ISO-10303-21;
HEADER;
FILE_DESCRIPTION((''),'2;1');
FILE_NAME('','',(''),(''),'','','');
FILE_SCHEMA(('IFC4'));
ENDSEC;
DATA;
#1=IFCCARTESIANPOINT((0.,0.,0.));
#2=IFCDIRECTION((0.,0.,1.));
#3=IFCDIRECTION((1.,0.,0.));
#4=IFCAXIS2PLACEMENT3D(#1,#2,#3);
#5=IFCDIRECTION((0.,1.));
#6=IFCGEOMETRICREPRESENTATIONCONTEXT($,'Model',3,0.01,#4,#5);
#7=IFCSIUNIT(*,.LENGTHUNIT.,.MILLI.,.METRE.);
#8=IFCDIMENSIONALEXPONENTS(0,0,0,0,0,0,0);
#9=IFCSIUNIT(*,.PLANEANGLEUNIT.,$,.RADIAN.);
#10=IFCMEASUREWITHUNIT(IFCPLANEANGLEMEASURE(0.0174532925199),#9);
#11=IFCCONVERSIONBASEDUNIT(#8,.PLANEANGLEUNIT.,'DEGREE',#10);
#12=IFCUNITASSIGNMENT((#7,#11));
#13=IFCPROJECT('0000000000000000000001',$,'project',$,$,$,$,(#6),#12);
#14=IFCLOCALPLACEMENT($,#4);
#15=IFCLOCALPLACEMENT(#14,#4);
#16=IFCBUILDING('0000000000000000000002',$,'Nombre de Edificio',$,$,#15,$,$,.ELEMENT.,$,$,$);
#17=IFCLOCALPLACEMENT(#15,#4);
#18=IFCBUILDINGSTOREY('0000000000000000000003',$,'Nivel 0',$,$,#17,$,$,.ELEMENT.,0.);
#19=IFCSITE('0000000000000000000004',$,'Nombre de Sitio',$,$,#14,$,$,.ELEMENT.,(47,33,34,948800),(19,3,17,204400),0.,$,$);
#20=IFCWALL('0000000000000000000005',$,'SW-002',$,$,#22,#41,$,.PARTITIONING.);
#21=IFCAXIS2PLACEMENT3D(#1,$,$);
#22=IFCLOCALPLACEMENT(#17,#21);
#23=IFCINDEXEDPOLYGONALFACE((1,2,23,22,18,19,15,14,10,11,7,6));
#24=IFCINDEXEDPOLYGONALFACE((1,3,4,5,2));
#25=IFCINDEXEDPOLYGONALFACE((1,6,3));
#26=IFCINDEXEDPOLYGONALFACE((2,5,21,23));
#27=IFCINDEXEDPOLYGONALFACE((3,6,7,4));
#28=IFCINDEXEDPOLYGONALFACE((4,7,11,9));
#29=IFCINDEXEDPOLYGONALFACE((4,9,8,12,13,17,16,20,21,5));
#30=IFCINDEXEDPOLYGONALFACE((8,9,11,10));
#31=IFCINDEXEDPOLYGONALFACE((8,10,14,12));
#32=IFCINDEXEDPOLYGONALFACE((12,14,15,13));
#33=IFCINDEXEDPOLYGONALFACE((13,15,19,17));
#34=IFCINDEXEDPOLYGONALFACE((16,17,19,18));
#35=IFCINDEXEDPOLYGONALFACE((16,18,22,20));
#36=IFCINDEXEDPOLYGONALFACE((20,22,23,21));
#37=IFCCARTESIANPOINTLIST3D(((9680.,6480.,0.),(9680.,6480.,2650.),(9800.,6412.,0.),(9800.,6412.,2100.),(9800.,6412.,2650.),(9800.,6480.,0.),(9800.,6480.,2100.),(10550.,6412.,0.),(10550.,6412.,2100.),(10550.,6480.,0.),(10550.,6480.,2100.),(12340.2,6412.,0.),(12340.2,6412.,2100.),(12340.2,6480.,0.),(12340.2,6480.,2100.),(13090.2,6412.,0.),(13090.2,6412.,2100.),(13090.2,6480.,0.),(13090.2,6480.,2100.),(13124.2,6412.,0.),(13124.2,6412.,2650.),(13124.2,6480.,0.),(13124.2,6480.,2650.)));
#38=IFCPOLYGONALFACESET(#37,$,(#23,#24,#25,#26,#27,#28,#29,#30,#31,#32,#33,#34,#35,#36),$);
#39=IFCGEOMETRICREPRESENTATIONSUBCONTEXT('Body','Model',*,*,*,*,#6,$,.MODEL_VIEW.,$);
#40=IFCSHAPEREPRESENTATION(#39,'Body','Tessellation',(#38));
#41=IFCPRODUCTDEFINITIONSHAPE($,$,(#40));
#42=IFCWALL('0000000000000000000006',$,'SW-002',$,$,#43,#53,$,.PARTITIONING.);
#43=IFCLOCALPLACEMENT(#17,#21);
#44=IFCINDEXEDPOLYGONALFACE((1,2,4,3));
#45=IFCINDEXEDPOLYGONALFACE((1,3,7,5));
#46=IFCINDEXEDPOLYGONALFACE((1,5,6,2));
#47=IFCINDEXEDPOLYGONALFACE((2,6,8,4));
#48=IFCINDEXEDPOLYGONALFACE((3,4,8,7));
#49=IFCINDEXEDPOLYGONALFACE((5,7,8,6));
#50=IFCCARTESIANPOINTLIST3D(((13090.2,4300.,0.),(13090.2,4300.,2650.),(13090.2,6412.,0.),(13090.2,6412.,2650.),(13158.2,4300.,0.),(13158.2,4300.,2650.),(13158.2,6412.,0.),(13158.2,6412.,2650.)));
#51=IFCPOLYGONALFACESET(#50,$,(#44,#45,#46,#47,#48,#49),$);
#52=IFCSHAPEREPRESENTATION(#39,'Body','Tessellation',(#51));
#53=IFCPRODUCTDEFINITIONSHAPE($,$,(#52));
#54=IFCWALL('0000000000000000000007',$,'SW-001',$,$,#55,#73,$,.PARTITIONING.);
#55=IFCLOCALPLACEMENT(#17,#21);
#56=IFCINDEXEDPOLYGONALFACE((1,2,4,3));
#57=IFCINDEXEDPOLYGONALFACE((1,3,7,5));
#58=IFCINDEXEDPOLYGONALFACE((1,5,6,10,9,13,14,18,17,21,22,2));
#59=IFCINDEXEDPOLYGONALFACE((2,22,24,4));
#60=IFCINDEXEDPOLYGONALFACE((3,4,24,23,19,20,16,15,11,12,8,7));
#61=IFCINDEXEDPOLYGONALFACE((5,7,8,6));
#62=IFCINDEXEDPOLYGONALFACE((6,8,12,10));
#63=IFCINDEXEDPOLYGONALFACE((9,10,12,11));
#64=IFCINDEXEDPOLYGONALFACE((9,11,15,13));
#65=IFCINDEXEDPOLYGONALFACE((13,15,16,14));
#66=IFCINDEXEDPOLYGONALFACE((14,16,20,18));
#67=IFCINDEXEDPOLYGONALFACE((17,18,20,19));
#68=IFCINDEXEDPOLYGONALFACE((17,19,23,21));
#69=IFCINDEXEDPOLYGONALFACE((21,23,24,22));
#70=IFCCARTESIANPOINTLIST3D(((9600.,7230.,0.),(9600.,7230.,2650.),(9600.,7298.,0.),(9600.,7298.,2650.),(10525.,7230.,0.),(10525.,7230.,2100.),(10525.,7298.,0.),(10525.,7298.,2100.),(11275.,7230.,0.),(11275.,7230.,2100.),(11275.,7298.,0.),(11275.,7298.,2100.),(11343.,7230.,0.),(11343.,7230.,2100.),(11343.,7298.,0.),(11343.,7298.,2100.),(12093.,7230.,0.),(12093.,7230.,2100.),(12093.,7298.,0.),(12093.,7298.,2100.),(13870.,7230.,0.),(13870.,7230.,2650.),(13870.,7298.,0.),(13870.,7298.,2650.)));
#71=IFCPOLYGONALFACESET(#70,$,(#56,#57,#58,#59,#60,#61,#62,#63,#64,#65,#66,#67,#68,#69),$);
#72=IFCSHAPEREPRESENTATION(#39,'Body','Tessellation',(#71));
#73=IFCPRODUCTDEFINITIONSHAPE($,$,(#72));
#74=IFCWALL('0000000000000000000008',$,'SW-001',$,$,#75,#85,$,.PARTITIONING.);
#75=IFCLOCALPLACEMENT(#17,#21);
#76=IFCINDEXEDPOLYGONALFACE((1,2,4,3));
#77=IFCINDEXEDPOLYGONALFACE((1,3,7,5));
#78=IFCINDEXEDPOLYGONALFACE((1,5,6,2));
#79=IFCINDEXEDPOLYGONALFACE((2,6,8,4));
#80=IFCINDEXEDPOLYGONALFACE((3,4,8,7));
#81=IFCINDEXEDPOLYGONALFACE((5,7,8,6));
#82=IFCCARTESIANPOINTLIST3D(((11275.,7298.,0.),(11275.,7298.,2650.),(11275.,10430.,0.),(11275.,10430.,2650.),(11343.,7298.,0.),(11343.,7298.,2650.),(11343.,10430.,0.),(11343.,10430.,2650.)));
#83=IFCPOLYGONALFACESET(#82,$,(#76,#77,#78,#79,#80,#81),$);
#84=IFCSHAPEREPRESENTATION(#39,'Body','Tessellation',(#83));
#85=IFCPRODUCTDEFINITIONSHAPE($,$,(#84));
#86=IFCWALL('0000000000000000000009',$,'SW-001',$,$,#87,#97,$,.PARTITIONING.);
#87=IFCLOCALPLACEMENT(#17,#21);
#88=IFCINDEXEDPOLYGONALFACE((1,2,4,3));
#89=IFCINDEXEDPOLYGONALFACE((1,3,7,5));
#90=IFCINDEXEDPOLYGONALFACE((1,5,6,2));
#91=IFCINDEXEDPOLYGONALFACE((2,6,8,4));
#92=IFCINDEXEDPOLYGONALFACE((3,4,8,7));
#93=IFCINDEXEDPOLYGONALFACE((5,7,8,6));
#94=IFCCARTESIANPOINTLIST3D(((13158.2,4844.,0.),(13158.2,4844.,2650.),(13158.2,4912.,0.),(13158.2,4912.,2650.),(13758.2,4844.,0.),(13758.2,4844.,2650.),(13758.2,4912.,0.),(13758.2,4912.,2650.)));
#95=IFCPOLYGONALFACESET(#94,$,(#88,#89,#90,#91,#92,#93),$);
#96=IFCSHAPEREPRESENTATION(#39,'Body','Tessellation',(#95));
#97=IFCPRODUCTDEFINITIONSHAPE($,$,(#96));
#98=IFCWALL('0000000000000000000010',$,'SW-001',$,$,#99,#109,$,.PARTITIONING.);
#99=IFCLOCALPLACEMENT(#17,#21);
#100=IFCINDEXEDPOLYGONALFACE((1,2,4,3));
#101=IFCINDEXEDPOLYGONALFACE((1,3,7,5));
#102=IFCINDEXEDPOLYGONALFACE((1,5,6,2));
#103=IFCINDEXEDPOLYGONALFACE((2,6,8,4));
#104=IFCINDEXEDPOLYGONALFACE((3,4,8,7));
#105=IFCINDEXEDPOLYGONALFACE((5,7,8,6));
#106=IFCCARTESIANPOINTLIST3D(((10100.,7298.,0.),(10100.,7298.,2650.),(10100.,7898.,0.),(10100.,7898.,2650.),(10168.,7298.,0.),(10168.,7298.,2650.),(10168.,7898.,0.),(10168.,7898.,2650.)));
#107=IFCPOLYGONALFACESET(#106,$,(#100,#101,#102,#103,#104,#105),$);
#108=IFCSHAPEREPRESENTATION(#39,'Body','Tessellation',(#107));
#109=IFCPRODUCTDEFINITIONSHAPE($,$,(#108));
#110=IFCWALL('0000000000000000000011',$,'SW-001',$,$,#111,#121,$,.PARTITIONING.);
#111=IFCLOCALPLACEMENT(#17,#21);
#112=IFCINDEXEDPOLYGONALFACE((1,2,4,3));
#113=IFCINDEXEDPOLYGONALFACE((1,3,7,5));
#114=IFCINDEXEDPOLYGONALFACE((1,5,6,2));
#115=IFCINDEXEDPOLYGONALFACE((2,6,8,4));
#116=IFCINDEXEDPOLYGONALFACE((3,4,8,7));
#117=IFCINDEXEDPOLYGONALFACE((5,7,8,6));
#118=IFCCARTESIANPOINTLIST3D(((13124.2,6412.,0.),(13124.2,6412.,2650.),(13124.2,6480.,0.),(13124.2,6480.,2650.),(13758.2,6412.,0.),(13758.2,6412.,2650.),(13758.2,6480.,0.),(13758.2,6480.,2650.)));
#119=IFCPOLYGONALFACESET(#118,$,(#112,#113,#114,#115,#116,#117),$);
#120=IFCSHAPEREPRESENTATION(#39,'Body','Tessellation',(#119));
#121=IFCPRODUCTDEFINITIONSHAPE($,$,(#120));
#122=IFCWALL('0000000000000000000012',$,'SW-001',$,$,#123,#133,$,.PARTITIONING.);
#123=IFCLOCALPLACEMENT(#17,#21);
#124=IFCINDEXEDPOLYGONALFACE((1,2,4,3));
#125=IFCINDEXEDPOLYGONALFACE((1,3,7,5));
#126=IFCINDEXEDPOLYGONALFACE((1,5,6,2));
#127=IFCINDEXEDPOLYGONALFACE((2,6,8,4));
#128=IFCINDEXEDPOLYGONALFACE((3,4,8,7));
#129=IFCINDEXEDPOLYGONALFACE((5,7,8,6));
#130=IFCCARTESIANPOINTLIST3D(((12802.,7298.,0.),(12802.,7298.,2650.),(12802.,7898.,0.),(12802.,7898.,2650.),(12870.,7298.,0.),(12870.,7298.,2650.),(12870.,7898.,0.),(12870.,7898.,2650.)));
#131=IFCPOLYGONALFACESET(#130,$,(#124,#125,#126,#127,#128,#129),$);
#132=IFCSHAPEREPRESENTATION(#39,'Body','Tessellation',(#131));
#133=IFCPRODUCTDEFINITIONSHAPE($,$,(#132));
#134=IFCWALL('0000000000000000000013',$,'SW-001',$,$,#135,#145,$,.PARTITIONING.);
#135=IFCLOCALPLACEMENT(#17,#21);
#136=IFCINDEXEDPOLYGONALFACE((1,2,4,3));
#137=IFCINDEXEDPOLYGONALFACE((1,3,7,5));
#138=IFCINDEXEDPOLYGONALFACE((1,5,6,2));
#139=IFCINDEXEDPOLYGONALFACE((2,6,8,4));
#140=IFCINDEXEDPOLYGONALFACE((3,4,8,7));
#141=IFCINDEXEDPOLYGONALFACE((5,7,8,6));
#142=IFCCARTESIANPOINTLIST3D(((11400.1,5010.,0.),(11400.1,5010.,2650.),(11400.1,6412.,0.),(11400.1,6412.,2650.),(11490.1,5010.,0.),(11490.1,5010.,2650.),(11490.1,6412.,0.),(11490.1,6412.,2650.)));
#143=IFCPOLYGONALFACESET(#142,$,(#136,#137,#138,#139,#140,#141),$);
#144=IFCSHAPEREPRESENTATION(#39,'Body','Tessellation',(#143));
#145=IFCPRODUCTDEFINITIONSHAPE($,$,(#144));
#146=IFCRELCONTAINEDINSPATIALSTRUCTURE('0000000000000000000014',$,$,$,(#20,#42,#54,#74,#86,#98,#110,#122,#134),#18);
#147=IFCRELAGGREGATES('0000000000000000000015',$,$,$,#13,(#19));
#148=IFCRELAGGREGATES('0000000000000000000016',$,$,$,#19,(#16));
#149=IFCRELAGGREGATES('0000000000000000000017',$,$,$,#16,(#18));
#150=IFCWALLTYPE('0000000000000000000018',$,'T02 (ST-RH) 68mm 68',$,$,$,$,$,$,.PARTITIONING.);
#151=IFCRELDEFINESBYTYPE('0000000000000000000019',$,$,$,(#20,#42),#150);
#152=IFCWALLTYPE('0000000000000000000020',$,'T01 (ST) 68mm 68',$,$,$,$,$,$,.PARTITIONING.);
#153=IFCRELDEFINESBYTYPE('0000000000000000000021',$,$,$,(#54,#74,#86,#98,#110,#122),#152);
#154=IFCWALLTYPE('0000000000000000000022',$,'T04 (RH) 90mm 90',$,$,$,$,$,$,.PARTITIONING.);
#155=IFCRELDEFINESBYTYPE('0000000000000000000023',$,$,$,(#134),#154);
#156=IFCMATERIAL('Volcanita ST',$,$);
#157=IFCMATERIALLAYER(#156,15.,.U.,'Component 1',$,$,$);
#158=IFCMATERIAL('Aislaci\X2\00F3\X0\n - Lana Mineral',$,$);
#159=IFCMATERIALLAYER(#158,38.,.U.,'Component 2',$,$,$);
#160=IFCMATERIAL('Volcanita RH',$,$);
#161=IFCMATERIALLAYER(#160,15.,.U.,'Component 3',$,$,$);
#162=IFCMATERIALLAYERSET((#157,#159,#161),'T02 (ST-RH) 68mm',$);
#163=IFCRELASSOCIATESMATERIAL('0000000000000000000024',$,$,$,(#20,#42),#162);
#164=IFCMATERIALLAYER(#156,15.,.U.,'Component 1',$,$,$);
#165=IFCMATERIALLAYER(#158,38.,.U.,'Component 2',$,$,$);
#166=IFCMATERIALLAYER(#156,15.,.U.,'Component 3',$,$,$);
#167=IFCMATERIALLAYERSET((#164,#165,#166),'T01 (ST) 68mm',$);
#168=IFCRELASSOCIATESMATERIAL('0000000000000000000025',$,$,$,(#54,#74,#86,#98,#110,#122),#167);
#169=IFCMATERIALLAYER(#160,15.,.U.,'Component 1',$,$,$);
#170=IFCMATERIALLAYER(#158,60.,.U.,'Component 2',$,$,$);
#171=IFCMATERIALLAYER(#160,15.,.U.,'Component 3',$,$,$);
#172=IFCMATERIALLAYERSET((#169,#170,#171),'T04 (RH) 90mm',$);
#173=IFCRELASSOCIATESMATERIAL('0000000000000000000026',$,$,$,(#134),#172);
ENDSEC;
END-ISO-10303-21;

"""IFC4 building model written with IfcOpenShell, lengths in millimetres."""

from ifc_helpers import new_model, entity, si_unit, converted_unit, direction, frame, origin_with_axes, origin_2d_with_axis, place, context, subcontext, project, spatial, line, indexed_curve, rectangle, outline, extrude, material, layer, layer_set, layer_usage, type_object, element, save


model = new_model("IFC4")

# Units and contexts
model_context = context("Model", 3, precision=0.01, world=origin_with_axes(), true_north=direction((0.0, 1.0)))
body_context = subcontext(model_context, "Body", "Model", "MODEL_VIEW")
ifc_project = project(units=[si_unit("LENGTHUNIT", "METRE", prefix="MILLI"), converted_unit("PLANEANGLEUNIT", "DEGREE", entity("IfcPlaneAngleMeasure", 0.0174532925199), si_unit("PLANEANGLEUNIT", "RADIAN"), dimensions=[0, 0, 0, 0, 0, 0, 0])], contexts=[model_context])

# Site, building, storey
site_placement = place(None, origin_with_axes())
site = spatial("IfcSite", under=ifc_project, at=site_placement, Name="Nombre de Sitio", CompositionType="ELEMENT", RefLatitude=(47, 33, 34, 948800), RefLongitude=(19, 3, 17, 204400), RefElevation=0.0)
building_placement = place(site_placement, origin_with_axes())
building = spatial("IfcBuilding", under=site, at=building_placement, Name="Nombre de Edificio", CompositionType="ELEMENT")
storey_placement = place(building_placement, origin_with_axes())
storey = spatial("IfcBuildingStorey", under=building, at=storey_placement, Name="Nivel 0", CompositionType="ELEMENT", Elevation=0.0)

# Wall, openings
ifc_material_1 = material(Name="Volcanita ST")
ifc_layer_1 = layer(ifc_material_1, 15.0, ventilated="UNKNOWN", Name="Component 1")
ifc_material_2 = material(Name="Aislación - Lana Mineral")
ifc_layer_2 = layer(ifc_material_2, 38.0, ventilated="UNKNOWN", Name="Component 2")
ifc_material_3 = material(Name="Volcanita RH")
ifc_layer_3 = layer(ifc_material_3, 15.0, ventilated="UNKNOWN", Name="Component 3")
ifc_layer_set_1 = layer_set([ifc_layer_1, ifc_layer_2, ifc_layer_3], Name="T02 (ST-RH) 68mm")
ifc_layer_usage_1 = layer_usage(ifc_layer_set_1, "AXIS2", "NEGATIVE", 34.0)
wall_type_1 = type_object("IfcWallType", Name="T02 (ST-RH) 68mm 68", PredefinedType="PARTITIONING")
wall_1_placement = place(storey_placement, frame((9740.0, 6446.0, 0.0), z_axis=(0.0, 0.0, 1.0), x_axis=(1.0, 0.0, 0.0)))
wall_1 = element("IfcWall", 1, at=wall_1_placement, inside=storey, type_object=wall_type_1, material=ifc_layer_usage_1, Name="SW-002", PredefinedType="PARTITIONING", context=body_context, shape_type="SweptSolid", body=[
    extrude(outline(indexed_curve([(60.0, -34.0), (3384.2, -34.0), (3384.2, 34.0), (-60.0, 34.0)], segments=[line(1, 2, 3, 4, 1)])), origin_with_axes(), (0.0, 0.0, 1.0), 2650.0),
])
opening_1_placement = place(wall_1_placement, frame((435.0, 0.0, 0.0), z_axis=(0.0, 0.0, 1.0), x_axis=(1.0, 0.0, 0.0)))
element("IfcOpeningElement", 2, at=opening_1_placement, cuts=wall_1, context=body_context, shape_type="SweptSolid", body=[
    extrude(rectangle(XDim=750.0, YDim=2100.0, at=origin_2d_with_axis()), frame((0.0, 68.0, 1050.0), z_axis=(0.0, -1.0, 0.0), x_axis=(-1.0, 0.0, 0.0)), (0.0, 0.0, 1.0), 204.0),
])
opening_2_placement = place(wall_1_placement, frame((2975.2, 0.0, 0.0), z_axis=(0.0, 0.0, 1.0), x_axis=(1.0, 0.0, 0.0)))
element("IfcOpeningElement", 3, at=opening_2_placement, cuts=wall_1, context=body_context, shape_type="SweptSolid", body=[
    extrude(rectangle(XDim=750.0, YDim=2100.0, at=origin_2d_with_axis()), frame((0.0, 68.0, 1050.0), z_axis=(0.0, 1.0, 0.0), x_axis=(1.0, 0.0, 0.0)), (0.0, 0.0, -1.0), 204.0),
])

# Wall
ifc_layer_usage_2 = layer_usage(ifc_layer_set_1, "AXIS2", "POSITIVE", -34.0)
wall_2_placement = place(storey_placement, frame((13124.2, 4300.0, 0.0), z_axis=(0.0, 0.0, 1.0), x_axis=(0.0, 1.0, 0.0)))
element("IfcWall", 4, at=wall_2_placement, inside=storey, type_object=wall_type_1, material=ifc_layer_usage_2, Name="SW-002", PredefinedType="PARTITIONING", context=body_context, shape_type="SweptSolid", body=[
    extrude(outline(indexed_curve([(0.0, -34.0), (2112.0, -34.0), (2112.0, 34.0), (0.0, 34.0)], segments=[line(1, 2, 3, 4, 1)])), origin_with_axes(), (0.0, 0.0, 1.0), 2650.0),
])

# Wall, openings
ifc_layer_4 = layer(ifc_material_1, 15.0, ventilated="UNKNOWN", Name="Component 1")
ifc_layer_5 = layer(ifc_material_2, 38.0, ventilated="UNKNOWN", Name="Component 2")
ifc_layer_6 = layer(ifc_material_1, 15.0, ventilated="UNKNOWN", Name="Component 3")
ifc_layer_set_2 = layer_set([ifc_layer_4, ifc_layer_5, ifc_layer_6], Name="T01 (ST) 68mm")
ifc_layer_usage_3 = layer_usage(ifc_layer_set_2, "AXIS2", "POSITIVE", -34.0)
wall_type_2 = type_object("IfcWallType", Name="T01 (ST) 68mm 68", PredefinedType="PARTITIONING")
wall_3_placement = place(storey_placement, frame((13870.0, 7264.0, 0.0), z_axis=(0.0, 0.0, 1.0), x_axis=(-1.0, 0.0, 0.0)))
wall_3 = element("IfcWall", 5, at=wall_3_placement, inside=storey, type_object=wall_type_2, material=ifc_layer_usage_3, Name="SW-001", PredefinedType="PARTITIONING", context=body_context, shape_type="SweptSolid", body=[
    extrude(outline(indexed_curve([(0.0, -34.0), (4270.0, -34.0), (4270.0, 34.0), (0.0, 34.0)], segments=[line(1, 2, 3, 4, 1)])), origin_with_axes(), (0.0, 0.0, 1.0), 2650.0),
])
opening_3_placement = place(wall_3_placement, frame((2970.0, 0.0, 0.0), z_axis=(0.0, 0.0, 1.0), x_axis=(1.0, 0.0, 0.0)))
element("IfcOpeningElement", 6, at=opening_3_placement, cuts=wall_3, context=body_context, shape_type="SweptSolid", body=[
    extrude(rectangle(XDim=750.0, YDim=2100.0, at=origin_2d_with_axis()), frame((0.0, 68.0, 1050.0), z_axis=(0.0, -1.0, 0.0), x_axis=(-1.0, 0.0, 0.0)), (0.0, 0.0, 1.0), 204.0),
])
opening_4_placement = place(wall_3_placement, frame((2152.0, 0.0, 0.0), z_axis=(0.0, 0.0, 1.0), x_axis=(1.0, 0.0, 0.0)))
element("IfcOpeningElement", 7, at=opening_4_placement, cuts=wall_3, context=body_context, shape_type="SweptSolid", body=[
    extrude(rectangle(XDim=750.0, YDim=2100.0, at=origin_2d_with_axis()), frame((0.0, 68.0, 1050.0), z_axis=(0.0, 1.0, 0.0), x_axis=(1.0, 0.0, 0.0)), (0.0, 0.0, -1.0), 204.0),
])

# Walls
ifc_layer_usage_4 = layer_usage(ifc_layer_set_2, "AXIS2", "POSITIVE", -34.0)
wall_4_placement = place(storey_placement, frame((11309.0, 10430.0, 0.0), z_axis=(0.0, 0.0, 1.0), x_axis=(0.0, -1.0, 0.0)))
element("IfcWall", 8, at=wall_4_placement, inside=storey, type_object=wall_type_2, material=ifc_layer_usage_4, Name="SW-001", PredefinedType="PARTITIONING", context=body_context, shape_type="SweptSolid", body=[
    extrude(outline(indexed_curve([(0.0, -34.0), (3132.0, -34.0), (3132.0, 34.0), (0.0, 34.0)], segments=[line(1, 2, 3, 4, 1)])), origin_with_axes(), (0.0, 0.0, 1.0), 2650.0),
])
ifc_layer_usage_5 = layer_usage(ifc_layer_set_2, "AXIS2", "POSITIVE", -34.0)
wall_5_placement = place(storey_placement, frame((13124.2, 4878.0, 0.0), z_axis=(0.0, 0.0, 1.0), x_axis=(1.0, 0.0, 0.0)))
element("IfcWall", 9, at=wall_5_placement, inside=storey, type_object=wall_type_2, material=ifc_layer_usage_5, Name="SW-001", PredefinedType="PARTITIONING", context=body_context, shape_type="SweptSolid", body=[
    extrude(outline(indexed_curve([(34.0, -34.0), (634.0, -34.0), (634.0, 34.0), (34.0, 34.0)], segments=[line(1, 2, 3, 4, 1)])), origin_with_axes(), (0.0, 0.0, 1.0), 2650.0),
])
ifc_layer_usage_6 = layer_usage(ifc_layer_set_2, "AXIS2", "POSITIVE", -34.0)
wall_6_placement = place(storey_placement, frame((10134.0, 7264.0, 0.0), z_axis=(0.0, 0.0, 1.0), x_axis=(0.0, 1.0, 0.0)))
element("IfcWall", 10, at=wall_6_placement, inside=storey, type_object=wall_type_2, material=ifc_layer_usage_6, Name="SW-001", PredefinedType="PARTITIONING", context=body_context, shape_type="SweptSolid", body=[
    extrude(outline(indexed_curve([(34.0, -34.0), (634.0, -34.0), (634.0, 34.0), (34.0, 34.0)], segments=[line(1, 2, 3, 4, 1)])), origin_with_axes(), (0.0, 0.0, 1.0), 2650.0),
])

# Walls
ifc_layer_usage_7 = layer_usage(ifc_layer_set_2, "AXIS2", "POSITIVE", -34.0)
wall_7_placement = place(storey_placement, frame((13124.2, 6446.0, 0.0), z_axis=(0.0, 0.0, 1.0), x_axis=(1.0, 0.0, 0.0)))
element("IfcWall", 11, at=wall_7_placement, inside=storey, type_object=wall_type_2, material=ifc_layer_usage_7, Name="SW-001", PredefinedType="PARTITIONING", context=body_context, shape_type="SweptSolid", body=[
    extrude(outline(indexed_curve([(0.0, -34.0), (634.0, -34.0), (634.0, 34.0), (0.0, 34.0)], segments=[line(1, 2, 3, 4, 1)])), origin_with_axes(), (0.0, 0.0, 1.0), 2650.0),
])
ifc_layer_usage_8 = layer_usage(ifc_layer_set_2, "AXIS2", "POSITIVE", -34.0)
wall_8_placement = place(storey_placement, frame((12836.0, 7264.0, 0.0), z_axis=(0.0, 0.0, 1.0), x_axis=(0.0, 1.0, 0.0)))
element("IfcWall", 12, at=wall_8_placement, inside=storey, type_object=wall_type_2, material=ifc_layer_usage_8, Name="SW-001", PredefinedType="PARTITIONING", context=body_context, shape_type="SweptSolid", body=[
    extrude(outline(indexed_curve([(34.0, -34.0), (634.0, -34.0), (634.0, 34.0), (34.0, 34.0)], segments=[line(1, 2, 3, 4, 1)])), origin_with_axes(), (0.0, 0.0, 1.0), 2650.0),
])

# Wall
ifc_layer_7 = layer(ifc_material_3, 15.0, ventilated="UNKNOWN", Name="Component 1")
ifc_layer_8 = layer(ifc_material_2, 60.0, ventilated="UNKNOWN", Name="Component 2")
ifc_layer_9 = layer(ifc_material_3, 15.0, ventilated="UNKNOWN", Name="Component 3")
ifc_layer_set_3 = layer_set([ifc_layer_7, ifc_layer_8, ifc_layer_9], Name="T04 (RH) 90mm")
ifc_layer_usage_9 = layer_usage(ifc_layer_set_3, "AXIS2", "POSITIVE", -45.0)
wall_type_3 = type_object("IfcWallType", Name="T04 (RH) 90mm 90", PredefinedType="PARTITIONING")
wall_9_placement = place(storey_placement, frame((11445.1, 5010.0, 0.0), z_axis=(0.0, 0.0, 1.0), x_axis=(0.0, 1.0, 0.0)))
element("IfcWall", 13, at=wall_9_placement, inside=storey, type_object=wall_type_3, material=ifc_layer_usage_9, Name="SW-001", PredefinedType="PARTITIONING", context=body_context, shape_type="SweptSolid", body=[
    extrude(outline(indexed_curve([(0.0, -45.0), (1402.0, -45.0), (1402.0, 45.0), (0.0, 45.0)], segments=[line(1, 2, 3, 4, 1)])), origin_with_axes(), (0.0, 0.0, 1.0), 2650.0),
])

save(model, "model.ifc")
